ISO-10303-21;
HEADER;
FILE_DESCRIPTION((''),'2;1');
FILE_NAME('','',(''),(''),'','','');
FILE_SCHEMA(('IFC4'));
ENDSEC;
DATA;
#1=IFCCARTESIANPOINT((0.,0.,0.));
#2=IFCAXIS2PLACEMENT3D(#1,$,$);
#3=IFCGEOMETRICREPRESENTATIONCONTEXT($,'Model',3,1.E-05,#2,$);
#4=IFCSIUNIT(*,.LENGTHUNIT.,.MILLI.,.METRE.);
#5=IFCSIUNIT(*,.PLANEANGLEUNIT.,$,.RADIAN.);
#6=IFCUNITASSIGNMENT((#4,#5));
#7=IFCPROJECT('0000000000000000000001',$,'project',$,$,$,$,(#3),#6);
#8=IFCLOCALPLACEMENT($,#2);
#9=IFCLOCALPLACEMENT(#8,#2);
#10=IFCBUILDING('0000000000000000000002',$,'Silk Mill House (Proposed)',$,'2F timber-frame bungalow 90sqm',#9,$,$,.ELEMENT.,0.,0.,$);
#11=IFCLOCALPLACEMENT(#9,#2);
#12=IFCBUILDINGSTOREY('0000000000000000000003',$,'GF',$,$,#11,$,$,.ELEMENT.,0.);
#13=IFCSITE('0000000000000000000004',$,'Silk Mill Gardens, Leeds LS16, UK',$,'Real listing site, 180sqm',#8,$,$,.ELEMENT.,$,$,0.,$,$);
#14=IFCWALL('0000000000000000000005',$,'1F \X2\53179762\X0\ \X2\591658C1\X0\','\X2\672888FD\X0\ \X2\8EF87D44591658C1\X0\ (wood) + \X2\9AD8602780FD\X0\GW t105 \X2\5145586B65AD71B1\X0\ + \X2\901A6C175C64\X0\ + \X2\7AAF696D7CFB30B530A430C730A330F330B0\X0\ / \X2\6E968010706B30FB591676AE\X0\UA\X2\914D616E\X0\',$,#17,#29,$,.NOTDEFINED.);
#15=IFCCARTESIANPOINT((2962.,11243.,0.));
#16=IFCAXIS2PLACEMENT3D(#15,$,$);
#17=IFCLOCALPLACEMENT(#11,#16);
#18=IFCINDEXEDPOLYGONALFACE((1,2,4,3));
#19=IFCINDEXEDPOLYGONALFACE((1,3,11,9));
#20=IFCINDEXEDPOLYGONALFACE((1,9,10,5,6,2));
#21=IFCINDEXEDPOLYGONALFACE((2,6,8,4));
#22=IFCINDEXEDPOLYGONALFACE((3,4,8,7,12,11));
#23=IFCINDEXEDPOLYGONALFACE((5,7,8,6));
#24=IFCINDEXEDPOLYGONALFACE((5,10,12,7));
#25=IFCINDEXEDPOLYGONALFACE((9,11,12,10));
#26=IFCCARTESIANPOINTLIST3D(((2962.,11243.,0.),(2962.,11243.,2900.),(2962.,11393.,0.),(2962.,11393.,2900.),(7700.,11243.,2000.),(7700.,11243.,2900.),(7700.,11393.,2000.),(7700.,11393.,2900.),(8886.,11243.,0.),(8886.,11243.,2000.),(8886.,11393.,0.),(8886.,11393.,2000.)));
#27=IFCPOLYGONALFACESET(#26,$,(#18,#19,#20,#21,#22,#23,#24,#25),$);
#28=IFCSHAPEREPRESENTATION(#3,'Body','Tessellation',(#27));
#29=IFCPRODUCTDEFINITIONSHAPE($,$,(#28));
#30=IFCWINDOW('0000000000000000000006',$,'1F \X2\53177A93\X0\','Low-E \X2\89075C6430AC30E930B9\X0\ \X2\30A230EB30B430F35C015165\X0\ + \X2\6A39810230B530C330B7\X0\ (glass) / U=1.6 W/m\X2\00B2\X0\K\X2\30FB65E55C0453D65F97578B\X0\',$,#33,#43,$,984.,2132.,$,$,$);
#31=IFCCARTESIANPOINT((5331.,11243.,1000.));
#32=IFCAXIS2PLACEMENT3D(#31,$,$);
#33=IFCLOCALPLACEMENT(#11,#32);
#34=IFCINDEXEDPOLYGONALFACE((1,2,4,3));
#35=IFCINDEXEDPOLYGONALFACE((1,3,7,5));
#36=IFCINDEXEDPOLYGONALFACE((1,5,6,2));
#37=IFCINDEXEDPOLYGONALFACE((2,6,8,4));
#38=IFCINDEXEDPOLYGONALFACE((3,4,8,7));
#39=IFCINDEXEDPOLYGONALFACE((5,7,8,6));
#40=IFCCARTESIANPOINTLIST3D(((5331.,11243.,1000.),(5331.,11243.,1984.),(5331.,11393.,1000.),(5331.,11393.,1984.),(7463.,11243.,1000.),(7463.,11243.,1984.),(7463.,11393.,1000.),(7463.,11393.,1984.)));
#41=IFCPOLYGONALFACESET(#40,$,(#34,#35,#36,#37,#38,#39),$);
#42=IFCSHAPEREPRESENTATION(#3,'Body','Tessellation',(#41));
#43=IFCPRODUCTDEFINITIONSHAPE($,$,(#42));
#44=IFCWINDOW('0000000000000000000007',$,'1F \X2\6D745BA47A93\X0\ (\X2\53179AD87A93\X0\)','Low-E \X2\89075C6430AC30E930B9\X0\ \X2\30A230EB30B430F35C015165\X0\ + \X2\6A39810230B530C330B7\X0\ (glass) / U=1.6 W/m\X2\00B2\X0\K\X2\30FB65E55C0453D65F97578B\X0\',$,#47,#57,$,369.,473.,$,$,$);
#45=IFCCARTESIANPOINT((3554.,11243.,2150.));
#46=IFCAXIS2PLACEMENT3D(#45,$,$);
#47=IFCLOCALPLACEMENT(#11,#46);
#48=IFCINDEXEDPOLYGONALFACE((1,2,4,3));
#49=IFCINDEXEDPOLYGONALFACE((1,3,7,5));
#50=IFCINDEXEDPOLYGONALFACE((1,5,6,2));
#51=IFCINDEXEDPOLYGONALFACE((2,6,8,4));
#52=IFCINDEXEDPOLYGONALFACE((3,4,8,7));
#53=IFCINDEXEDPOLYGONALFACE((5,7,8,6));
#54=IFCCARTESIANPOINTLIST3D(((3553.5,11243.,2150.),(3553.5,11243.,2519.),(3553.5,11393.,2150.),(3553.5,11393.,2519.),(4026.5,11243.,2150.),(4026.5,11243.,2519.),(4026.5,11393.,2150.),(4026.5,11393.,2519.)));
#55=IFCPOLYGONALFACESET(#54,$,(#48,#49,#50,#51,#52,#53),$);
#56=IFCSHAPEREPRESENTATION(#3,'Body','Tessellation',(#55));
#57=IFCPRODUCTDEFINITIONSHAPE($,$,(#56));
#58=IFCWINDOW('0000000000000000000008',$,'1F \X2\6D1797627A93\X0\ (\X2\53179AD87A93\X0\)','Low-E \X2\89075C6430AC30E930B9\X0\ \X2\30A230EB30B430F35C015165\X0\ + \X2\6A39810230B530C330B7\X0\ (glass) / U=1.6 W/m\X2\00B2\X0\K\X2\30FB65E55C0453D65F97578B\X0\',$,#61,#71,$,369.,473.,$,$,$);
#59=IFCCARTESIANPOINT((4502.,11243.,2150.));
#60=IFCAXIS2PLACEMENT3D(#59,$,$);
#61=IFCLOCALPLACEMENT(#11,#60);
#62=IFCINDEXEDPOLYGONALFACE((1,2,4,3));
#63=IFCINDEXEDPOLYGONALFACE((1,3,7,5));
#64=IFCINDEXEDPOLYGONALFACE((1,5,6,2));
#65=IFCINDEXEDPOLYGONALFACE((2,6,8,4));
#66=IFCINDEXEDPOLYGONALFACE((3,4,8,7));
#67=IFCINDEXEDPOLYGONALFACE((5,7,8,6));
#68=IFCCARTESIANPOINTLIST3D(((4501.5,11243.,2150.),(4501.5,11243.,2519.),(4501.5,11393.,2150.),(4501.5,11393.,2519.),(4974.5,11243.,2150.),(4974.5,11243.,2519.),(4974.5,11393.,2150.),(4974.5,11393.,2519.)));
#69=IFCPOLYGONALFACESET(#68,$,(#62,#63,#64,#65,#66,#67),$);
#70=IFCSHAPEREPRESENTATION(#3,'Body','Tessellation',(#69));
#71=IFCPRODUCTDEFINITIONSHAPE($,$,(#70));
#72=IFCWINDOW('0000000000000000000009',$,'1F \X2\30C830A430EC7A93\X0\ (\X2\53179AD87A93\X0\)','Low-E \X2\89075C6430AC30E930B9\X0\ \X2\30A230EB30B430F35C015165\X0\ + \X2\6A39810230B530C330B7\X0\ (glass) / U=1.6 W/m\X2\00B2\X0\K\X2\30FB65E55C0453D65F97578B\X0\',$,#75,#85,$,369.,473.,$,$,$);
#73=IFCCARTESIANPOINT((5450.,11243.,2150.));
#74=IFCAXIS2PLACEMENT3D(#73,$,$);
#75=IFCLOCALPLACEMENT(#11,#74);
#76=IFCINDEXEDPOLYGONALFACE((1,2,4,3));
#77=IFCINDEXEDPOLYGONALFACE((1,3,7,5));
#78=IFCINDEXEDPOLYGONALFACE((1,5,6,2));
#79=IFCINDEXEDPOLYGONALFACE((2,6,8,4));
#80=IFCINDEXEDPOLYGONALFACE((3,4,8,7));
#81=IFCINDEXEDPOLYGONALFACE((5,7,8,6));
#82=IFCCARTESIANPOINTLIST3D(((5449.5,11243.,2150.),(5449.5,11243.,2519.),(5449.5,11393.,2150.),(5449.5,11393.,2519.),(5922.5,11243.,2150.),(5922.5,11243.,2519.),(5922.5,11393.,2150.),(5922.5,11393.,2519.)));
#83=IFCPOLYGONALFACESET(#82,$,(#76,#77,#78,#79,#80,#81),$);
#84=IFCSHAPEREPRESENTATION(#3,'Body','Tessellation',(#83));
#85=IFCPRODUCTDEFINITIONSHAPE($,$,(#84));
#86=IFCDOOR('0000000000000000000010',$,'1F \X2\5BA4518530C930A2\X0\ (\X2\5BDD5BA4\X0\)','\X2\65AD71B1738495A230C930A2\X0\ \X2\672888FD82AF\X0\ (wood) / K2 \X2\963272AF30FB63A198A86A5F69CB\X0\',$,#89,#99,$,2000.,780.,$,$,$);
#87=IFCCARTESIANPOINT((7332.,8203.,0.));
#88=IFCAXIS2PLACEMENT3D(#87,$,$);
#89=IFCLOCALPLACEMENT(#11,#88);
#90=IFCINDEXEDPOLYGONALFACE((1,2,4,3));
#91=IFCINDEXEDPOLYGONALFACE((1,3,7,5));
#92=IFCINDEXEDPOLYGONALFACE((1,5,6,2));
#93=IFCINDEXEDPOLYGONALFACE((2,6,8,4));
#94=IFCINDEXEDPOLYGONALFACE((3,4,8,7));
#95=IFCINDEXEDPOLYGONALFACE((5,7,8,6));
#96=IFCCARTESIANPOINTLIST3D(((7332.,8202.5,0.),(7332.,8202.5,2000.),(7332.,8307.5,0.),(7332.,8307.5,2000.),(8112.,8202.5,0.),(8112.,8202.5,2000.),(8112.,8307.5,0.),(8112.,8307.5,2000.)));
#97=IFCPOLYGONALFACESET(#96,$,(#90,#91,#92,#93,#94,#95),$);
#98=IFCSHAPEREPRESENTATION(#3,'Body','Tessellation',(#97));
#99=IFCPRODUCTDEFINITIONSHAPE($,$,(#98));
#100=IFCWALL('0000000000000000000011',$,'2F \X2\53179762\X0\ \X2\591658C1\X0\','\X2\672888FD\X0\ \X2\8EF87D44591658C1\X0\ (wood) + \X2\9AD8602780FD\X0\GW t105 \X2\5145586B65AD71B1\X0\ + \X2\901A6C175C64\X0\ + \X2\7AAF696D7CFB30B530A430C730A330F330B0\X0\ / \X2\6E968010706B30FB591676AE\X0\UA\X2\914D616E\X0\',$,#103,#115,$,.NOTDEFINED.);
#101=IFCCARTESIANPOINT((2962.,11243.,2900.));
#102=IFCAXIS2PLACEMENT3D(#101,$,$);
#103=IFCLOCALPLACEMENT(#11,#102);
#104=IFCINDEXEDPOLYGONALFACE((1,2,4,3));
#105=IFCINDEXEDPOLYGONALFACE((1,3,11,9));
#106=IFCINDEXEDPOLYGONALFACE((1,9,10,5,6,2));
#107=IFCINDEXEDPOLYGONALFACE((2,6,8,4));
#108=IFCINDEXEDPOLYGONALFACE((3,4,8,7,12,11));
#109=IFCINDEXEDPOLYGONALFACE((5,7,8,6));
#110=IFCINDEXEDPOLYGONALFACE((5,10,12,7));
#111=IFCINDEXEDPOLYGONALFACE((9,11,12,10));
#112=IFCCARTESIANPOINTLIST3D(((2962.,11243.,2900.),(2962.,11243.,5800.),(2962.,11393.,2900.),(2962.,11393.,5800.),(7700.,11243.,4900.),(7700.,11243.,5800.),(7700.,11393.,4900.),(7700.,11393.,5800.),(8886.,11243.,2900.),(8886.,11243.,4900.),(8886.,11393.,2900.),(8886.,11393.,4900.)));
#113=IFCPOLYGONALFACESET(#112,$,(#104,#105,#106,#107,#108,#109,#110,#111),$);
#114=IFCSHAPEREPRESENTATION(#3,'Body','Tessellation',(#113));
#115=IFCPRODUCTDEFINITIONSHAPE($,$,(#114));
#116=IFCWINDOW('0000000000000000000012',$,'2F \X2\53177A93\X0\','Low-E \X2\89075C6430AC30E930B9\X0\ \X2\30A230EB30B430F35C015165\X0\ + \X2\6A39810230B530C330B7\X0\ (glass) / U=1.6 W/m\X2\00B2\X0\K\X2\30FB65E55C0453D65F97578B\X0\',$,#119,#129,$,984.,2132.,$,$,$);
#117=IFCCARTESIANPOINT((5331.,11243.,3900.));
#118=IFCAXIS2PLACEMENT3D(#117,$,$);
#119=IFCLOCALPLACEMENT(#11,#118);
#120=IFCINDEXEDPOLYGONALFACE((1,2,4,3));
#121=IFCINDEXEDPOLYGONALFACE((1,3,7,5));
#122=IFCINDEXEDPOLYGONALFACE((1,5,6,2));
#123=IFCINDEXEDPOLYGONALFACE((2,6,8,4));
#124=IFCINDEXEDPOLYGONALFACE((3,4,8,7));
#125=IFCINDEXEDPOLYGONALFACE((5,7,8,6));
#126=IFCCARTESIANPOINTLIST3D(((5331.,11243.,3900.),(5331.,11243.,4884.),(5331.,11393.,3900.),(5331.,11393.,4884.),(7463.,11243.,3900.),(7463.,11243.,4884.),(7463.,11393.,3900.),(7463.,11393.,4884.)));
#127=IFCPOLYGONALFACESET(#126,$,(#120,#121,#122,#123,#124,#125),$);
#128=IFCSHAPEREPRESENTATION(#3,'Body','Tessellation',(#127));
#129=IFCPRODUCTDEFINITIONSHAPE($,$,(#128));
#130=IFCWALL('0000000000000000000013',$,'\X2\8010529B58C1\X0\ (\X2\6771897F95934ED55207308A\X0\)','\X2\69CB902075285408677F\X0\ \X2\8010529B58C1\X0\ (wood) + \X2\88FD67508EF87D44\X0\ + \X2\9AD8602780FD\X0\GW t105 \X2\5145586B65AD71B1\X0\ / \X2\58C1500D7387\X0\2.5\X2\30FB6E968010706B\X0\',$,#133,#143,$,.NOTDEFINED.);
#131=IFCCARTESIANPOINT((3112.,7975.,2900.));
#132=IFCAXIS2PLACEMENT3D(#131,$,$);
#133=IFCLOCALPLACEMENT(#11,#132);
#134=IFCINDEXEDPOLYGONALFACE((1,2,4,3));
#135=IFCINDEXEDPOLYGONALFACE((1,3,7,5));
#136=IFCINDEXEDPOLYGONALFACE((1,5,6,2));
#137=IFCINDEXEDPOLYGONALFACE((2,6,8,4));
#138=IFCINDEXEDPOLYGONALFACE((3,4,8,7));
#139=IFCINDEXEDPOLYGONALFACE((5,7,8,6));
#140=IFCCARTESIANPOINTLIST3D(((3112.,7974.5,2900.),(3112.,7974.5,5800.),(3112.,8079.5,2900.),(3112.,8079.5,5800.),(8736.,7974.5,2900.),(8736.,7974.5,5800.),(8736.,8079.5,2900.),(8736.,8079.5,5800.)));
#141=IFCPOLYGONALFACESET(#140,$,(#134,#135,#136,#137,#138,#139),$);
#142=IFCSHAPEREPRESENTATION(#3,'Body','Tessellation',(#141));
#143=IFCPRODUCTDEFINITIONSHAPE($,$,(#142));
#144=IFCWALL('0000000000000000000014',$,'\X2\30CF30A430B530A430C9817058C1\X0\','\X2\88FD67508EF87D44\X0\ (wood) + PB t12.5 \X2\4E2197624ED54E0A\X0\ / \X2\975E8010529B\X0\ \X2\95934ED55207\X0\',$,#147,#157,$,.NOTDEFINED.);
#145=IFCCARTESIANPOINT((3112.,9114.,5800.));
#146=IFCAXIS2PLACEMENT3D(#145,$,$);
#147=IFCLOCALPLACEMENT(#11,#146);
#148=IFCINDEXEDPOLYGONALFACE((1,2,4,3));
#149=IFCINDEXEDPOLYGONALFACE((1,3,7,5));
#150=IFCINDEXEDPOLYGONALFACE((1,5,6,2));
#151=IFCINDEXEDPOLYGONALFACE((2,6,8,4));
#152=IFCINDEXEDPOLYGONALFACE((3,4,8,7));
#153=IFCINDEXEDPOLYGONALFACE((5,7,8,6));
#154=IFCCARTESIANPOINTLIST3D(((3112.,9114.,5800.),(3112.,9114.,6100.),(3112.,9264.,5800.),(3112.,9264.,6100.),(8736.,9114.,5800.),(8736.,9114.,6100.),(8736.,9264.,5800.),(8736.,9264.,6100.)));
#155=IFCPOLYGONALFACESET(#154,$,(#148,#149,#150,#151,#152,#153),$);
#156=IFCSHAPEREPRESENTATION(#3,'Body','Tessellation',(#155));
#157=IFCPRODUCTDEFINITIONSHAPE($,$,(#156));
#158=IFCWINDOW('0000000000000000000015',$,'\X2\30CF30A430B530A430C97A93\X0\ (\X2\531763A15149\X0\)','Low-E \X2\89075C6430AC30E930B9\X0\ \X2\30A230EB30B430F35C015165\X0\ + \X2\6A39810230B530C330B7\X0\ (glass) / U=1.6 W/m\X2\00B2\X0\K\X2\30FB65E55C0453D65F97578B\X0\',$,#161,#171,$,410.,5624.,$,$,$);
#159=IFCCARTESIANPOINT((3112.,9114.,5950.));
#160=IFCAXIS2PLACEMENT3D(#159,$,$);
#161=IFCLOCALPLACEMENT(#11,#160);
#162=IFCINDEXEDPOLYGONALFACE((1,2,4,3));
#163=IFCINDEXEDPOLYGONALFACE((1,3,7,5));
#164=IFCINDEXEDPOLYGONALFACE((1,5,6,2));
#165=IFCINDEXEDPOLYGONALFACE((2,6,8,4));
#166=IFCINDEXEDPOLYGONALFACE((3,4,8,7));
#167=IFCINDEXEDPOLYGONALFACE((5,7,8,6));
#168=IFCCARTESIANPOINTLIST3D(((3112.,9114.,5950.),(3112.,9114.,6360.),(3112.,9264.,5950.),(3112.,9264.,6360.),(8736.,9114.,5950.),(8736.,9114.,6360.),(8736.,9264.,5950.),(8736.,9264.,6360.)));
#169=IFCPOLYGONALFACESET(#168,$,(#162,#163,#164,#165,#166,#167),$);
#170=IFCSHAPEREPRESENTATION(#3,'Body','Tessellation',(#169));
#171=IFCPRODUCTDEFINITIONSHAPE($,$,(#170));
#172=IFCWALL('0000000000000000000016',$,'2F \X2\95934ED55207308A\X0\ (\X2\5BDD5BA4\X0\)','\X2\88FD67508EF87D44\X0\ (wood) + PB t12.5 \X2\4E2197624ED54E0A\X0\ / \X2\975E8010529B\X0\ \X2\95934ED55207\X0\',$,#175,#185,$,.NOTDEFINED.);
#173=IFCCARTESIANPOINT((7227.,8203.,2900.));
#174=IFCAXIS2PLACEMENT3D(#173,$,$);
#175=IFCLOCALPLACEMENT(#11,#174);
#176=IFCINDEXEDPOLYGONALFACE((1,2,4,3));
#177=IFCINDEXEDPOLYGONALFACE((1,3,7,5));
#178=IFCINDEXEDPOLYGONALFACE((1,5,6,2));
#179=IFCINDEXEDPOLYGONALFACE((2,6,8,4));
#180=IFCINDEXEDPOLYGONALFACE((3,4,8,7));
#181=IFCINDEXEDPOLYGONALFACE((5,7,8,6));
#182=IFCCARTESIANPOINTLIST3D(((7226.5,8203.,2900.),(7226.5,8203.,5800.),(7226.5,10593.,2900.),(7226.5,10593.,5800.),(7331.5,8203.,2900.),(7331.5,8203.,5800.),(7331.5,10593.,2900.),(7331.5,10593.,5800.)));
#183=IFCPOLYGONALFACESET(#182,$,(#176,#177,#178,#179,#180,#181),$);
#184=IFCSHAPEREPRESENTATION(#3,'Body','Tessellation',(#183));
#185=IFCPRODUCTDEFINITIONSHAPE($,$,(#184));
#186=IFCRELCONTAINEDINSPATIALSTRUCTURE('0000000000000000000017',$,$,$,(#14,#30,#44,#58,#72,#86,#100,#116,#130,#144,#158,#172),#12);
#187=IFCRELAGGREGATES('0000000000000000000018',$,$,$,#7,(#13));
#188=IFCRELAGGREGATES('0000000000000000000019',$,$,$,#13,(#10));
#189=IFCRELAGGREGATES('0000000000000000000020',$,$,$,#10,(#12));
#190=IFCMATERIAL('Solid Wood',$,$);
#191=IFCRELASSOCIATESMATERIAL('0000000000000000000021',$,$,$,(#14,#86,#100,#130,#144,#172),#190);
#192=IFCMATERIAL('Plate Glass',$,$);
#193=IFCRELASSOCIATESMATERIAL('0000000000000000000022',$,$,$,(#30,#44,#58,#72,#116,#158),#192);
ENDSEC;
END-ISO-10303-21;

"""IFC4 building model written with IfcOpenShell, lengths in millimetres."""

from ifc_helpers import new_model, si_unit, frame, frame_2d, origin, place, context, project, spatial, rectangle, extrude, material, element, fill, save


model = new_model("IFC4")

# Units and contexts
model_context = context("Model", 3, precision=1e-05, world=origin())
ifc_project = project(units=[si_unit("LENGTHUNIT", "METRE", prefix="MILLI"), si_unit("PLANEANGLEUNIT", "RADIAN")], contexts=[model_context])

# Site, building, storey
site_placement = place(None, origin())
site = spatial("IfcSite", under=ifc_project, at=site_placement, Name="Silk Mill Gardens, Leeds LS16, UK", ObjectType="Real listing site, 180sqm", CompositionType="ELEMENT", RefElevation=0.0)
building_placement = place(site_placement, origin())
building = spatial("IfcBuilding", under=site, at=building_placement, Name="Silk Mill House (Proposed)", ObjectType="2F timber-frame bungalow 90sqm", CompositionType="ELEMENT", ElevationOfRefHeight=0.0, ElevationOfTerrain=0.0)
storey_placement = place(building_placement, origin())
storey = spatial("IfcBuildingStorey", under=building, at=storey_placement, Name="GF", CompositionType="ELEMENT", Elevation=0.0)

# Wall, openings, windows
ifc_material_1 = material(Name="Solid Wood")
wall_1_placement = place(storey_placement, frame((2962.0, 11243.0, 0.0)))
wall_1 = element("IfcWall", 1, at=wall_1_placement, inside=storey, material=ifc_material_1, Name="1F 北面 外壁", Description="木製 軸組外壁 (wood) + 高性能GW t105 充填断熱 + 通気層 + 窯業系サイディング / 準耐火・外皮UA配慮", PredefinedType="NOTDEFINED", context=model_context, shape_type="SweptSolid", body=[
    extrude(rectangle(XDim=5924.0, YDim=150.0, at=frame_2d((2962.0, 75.0))), frame((2962.0, 11243.0, 0.0)), (0.0, 0.0, 1.0), 2900.0),
])
opening_1_placement = place(storey_placement, frame((5331.0, 11243.0, 1000.0)))
opening_1 = element("IfcOpeningElement", 2, at=opening_1_placement, cuts=wall_1, PredefinedType="NOTDEFINED", context=model_context, shape_type="SweptSolid", body=[
    extrude(rectangle(XDim=2132.0, YDim=150.0, at=frame_2d((1066.0, 75.0))), frame((5331.0, 11243.0, 1000.0)), (0.0, 0.0, 1.0), 984.0),
])
opening_2_placement = place(storey_placement, frame((3554.0, 11243.0, 2150.0)))
opening_2 = element("IfcOpeningElement", 3, at=opening_2_placement, cuts=wall_1, PredefinedType="NOTDEFINED", context=model_context, shape_type="SweptSolid", body=[
    extrude(rectangle(XDim=473.0, YDim=150.0, at=frame_2d((236.0, 75.0))), frame((3554.0, 11243.0, 2150.0)), (0.0, 0.0, 1.0), 369.0),
])
opening_3_placement = place(storey_placement, frame((4502.0, 11243.0, 2150.0)))
opening_3 = element("IfcOpeningElement", 4, at=opening_3_placement, cuts=wall_1, PredefinedType="NOTDEFINED", context=model_context, shape_type="SweptSolid", body=[
    extrude(rectangle(XDim=473.0, YDim=150.0, at=frame_2d((236.0, 75.0))), frame((4502.0, 11243.0, 2150.0)), (0.0, 0.0, 1.0), 369.0),
])
opening_4_placement = place(storey_placement, frame((5450.0, 11243.0, 2150.0)))
opening_4 = element("IfcOpeningElement", 5, at=opening_4_placement, cuts=wall_1, PredefinedType="NOTDEFINED", context=model_context, shape_type="SweptSolid", body=[
    extrude(rectangle(XDim=473.0, YDim=150.0, at=frame_2d((236.0, 75.0))), frame((5450.0, 11243.0, 2150.0)), (0.0, 0.0, 1.0), 369.0),
])
ifc_material_2 = material(Name="Plate Glass")
window_1_placement = place(storey_placement, frame((5331.0, 11243.0, 1000.0)))
window_1 = element("IfcWindow", 6, at=window_1_placement, inside=storey, material=ifc_material_2, Name="1F 北窓", Description="Low-E 複層ガラス アルゴン封入 + 樹脂サッシ (glass) / U=1.6 W/m²K・日射取得型", OverallHeight=984.0, OverallWidth=2132.0, context=model_context, shape_type="SweptSolid", body=[
    extrude(rectangle(XDim=2132.0, YDim=150.0, at=frame_2d((1066.0, 75.0))), frame((5331.0, 11243.0, 1000.0)), (0.0, 0.0, 1.0), 984.0),
])
fill(opening_1, window_1)
window_2_placement = place(storey_placement, frame((3554.0, 11243.0, 2150.0)))
window_2 = element("IfcWindow", 7, at=window_2_placement, inside=storey, material=ifc_material_2, Name="1F 浴室窓 (北高窓)", Description="Low-E 複層ガラス アルゴン封入 + 樹脂サッシ (glass) / U=1.6 W/m²K・日射取得型", OverallHeight=369.0, OverallWidth=473.0, context=model_context, shape_type="SweptSolid", body=[
    extrude(rectangle(XDim=473.0, YDim=150.0, at=frame_2d((236.0, 75.0))), frame((3554.0, 11243.0, 2150.0)), (0.0, 0.0, 1.0), 369.0),
])
fill(opening_2, window_2)
window_3_placement = place(storey_placement, frame((4502.0, 11243.0, 2150.0)))
window_3 = element("IfcWindow", 8, at=window_3_placement, inside=storey, material=ifc_material_2, Name="1F 洗面窓 (北高窓)", Description="Low-E 複層ガラス アルゴン封入 + 樹脂サッシ (glass) / U=1.6 W/m²K・日射取得型", OverallHeight=369.0, OverallWidth=473.0, context=model_context, shape_type="SweptSolid", body=[
    extrude(rectangle(XDim=473.0, YDim=150.0, at=frame_2d((236.0, 75.0))), frame((4502.0, 11243.0, 2150.0)), (0.0, 0.0, 1.0), 369.0),
])
fill(opening_3, window_3)
window_4_placement = place(storey_placement, frame((5450.0, 11243.0, 2150.0)))
window_4 = element("IfcWindow", 9, at=window_4_placement, inside=storey, material=ifc_material_2, Name="1F トイレ窓 (北高窓)", Description="Low-E 複層ガラス アルゴン封入 + 樹脂サッシ (glass) / U=1.6 W/m²K・日射取得型", OverallHeight=369.0, OverallWidth=473.0, context=model_context, shape_type="SweptSolid", body=[
    extrude(rectangle(XDim=473.0, YDim=150.0, at=frame_2d((236.0, 75.0))), frame((5450.0, 11243.0, 2150.0)), (0.0, 0.0, 1.0), 369.0),
])
fill(opening_4, window_4)

# Door
door_1_placement = place(storey_placement, frame((7332.0, 8203.0, 0.0)))
element("IfcDoor", 10, at=door_1_placement, inside=storey, material=ifc_material_1, Name="1F 室内ドア (寝室)", Description="断熱玄関ドア 木製芯 (wood) / K2 防犯・採風機構", OverallHeight=2000.0, OverallWidth=780.0, context=model_context, shape_type="SweptSolid", body=[
    extrude(rectangle(XDim=780.0, YDim=105.0, at=frame_2d((390.0, 52.0))), frame((7332.0, 8203.0, 0.0)), (0.0, 0.0, 1.0), 2000.0),
])

# Wall, opening, window
wall_2_placement = place(storey_placement, frame((2962.0, 11243.0, 2900.0)))
wall_2 = element("IfcWall", 11, at=wall_2_placement, inside=storey, material=ifc_material_1, Name="2F 北面 外壁", Description="木製 軸組外壁 (wood) + 高性能GW t105 充填断熱 + 通気層 + 窯業系サイディング / 準耐火・外皮UA配慮", PredefinedType="NOTDEFINED", context=model_context, shape_type="SweptSolid", body=[
    extrude(rectangle(XDim=5924.0, YDim=150.0, at=frame_2d((2962.0, 75.0))), frame((2962.0, 11243.0, 2900.0)), (0.0, 0.0, 1.0), 2900.0),
])
opening_5_placement = place(storey_placement, frame((5331.0, 11243.0, 3900.0)))
opening_5 = element("IfcOpeningElement", 12, at=opening_5_placement, cuts=wall_2, PredefinedType="NOTDEFINED", context=model_context, shape_type="SweptSolid", body=[
    extrude(rectangle(XDim=2132.0, YDim=150.0, at=frame_2d((1066.0, 75.0))), frame((5331.0, 11243.0, 3900.0)), (0.0, 0.0, 1.0), 984.0),
])
window_5_placement = place(storey_placement, frame((5331.0, 11243.0, 3900.0)))
window_5 = element("IfcWindow", 13, at=window_5_placement, inside=storey, material=ifc_material_2, Name="2F 北窓", Description="Low-E 複層ガラス アルゴン封入 + 樹脂サッシ (glass) / U=1.6 W/m²K・日射取得型", OverallHeight=984.0, OverallWidth=2132.0, context=model_context, shape_type="SweptSolid", body=[
    extrude(rectangle(XDim=2132.0, YDim=150.0, at=frame_2d((1066.0, 75.0))), frame((5331.0, 11243.0, 3900.0)), (0.0, 0.0, 1.0), 984.0),
])
fill(opening_5, window_5)

# Wall
wall_3_placement = place(storey_placement, frame((3112.0, 7975.0, 2900.0)))
element("IfcWall", 14, at=wall_3_placement, inside=storey, material=ifc_material_1, Name="耐力壁 (東西間仕切り)", Description="構造用合板 耐力壁 (wood) + 製材軸組 + 高性能GW t105 充填断熱 / 壁倍率2.5・準耐火", PredefinedType="NOTDEFINED", context=model_context, shape_type="SweptSolid", body=[
    extrude(rectangle(XDim=5624.0, YDim=105.0, at=frame_2d((2812.0, 52.0))), frame((3112.0, 7975.0, 2900.0)), (0.0, 0.0, 1.0), 2900.0),
])

# Wall, opening, window
wall_4_placement = place(storey_placement, frame((3112.0, 9114.0, 5800.0)))
wall_4 = element("IfcWall", 15, at=wall_4_placement, inside=storey, material=ifc_material_1, Name="ハイサイド腰壁", Description="製材軸組 (wood) + PB t12.5 両面仕上 / 非耐力 間仕切", PredefinedType="NOTDEFINED", context=model_context, shape_type="SweptSolid", body=[
    extrude(rectangle(XDim=5624.0, YDim=150.0, at=frame_2d((2812.0, 75.0))), frame((3112.0, 9114.0, 5800.0)), (0.0, 0.0, 1.0), 700.0),
])
opening_6_placement = place(storey_placement, frame((3112.0, 9114.0, 5950.0)))
opening_6 = element("IfcOpeningElement", 16, at=opening_6_placement, cuts=wall_4, PredefinedType="NOTDEFINED", context=model_context, shape_type="SweptSolid", body=[
    extrude(rectangle(XDim=5624.0, YDim=150.0, at=frame_2d((2812.0, 75.0))), frame((3112.0, 9114.0, 5950.0)), (0.0, 0.0, 1.0), 410.0),
])
window_6_placement = place(storey_placement, frame((3112.0, 9114.0, 5950.0)))
window_6 = element("IfcWindow", 17, at=window_6_placement, inside=storey, material=ifc_material_2, Name="ハイサイド窓 (北採光)", Description="Low-E 複層ガラス アルゴン封入 + 樹脂サッシ (glass) / U=1.6 W/m²K・日射取得型", OverallHeight=410.0, OverallWidth=5624.0, context=model_context, shape_type="SweptSolid", body=[
    extrude(rectangle(XDim=5624.0, YDim=150.0, at=frame_2d((2812.0, 75.0))), frame((3112.0, 9114.0, 5950.0)), (0.0, 0.0, 1.0), 410.0),
])
fill(opening_6, window_6)

# Wall
wall_5_placement = place(storey_placement, frame((7227.0, 8203.0, 2900.0)))
element("IfcWall", 18, at=wall_5_placement, inside=storey, material=ifc_material_1, Name="2F 間仕切り (寝室)", Description="製材軸組 (wood) + PB t12.5 両面仕上 / 非耐力 間仕切", PredefinedType="NOTDEFINED", context=model_context, shape_type="SweptSolid", body=[
    extrude(rectangle(XDim=105.0, YDim=2390.0, at=frame_2d((52.0, 1195.0))), frame((7227.0, 8203.0, 2900.0)), (0.0, 0.0, 1.0), 2900.0),
])

save(model, "model.ifc")
